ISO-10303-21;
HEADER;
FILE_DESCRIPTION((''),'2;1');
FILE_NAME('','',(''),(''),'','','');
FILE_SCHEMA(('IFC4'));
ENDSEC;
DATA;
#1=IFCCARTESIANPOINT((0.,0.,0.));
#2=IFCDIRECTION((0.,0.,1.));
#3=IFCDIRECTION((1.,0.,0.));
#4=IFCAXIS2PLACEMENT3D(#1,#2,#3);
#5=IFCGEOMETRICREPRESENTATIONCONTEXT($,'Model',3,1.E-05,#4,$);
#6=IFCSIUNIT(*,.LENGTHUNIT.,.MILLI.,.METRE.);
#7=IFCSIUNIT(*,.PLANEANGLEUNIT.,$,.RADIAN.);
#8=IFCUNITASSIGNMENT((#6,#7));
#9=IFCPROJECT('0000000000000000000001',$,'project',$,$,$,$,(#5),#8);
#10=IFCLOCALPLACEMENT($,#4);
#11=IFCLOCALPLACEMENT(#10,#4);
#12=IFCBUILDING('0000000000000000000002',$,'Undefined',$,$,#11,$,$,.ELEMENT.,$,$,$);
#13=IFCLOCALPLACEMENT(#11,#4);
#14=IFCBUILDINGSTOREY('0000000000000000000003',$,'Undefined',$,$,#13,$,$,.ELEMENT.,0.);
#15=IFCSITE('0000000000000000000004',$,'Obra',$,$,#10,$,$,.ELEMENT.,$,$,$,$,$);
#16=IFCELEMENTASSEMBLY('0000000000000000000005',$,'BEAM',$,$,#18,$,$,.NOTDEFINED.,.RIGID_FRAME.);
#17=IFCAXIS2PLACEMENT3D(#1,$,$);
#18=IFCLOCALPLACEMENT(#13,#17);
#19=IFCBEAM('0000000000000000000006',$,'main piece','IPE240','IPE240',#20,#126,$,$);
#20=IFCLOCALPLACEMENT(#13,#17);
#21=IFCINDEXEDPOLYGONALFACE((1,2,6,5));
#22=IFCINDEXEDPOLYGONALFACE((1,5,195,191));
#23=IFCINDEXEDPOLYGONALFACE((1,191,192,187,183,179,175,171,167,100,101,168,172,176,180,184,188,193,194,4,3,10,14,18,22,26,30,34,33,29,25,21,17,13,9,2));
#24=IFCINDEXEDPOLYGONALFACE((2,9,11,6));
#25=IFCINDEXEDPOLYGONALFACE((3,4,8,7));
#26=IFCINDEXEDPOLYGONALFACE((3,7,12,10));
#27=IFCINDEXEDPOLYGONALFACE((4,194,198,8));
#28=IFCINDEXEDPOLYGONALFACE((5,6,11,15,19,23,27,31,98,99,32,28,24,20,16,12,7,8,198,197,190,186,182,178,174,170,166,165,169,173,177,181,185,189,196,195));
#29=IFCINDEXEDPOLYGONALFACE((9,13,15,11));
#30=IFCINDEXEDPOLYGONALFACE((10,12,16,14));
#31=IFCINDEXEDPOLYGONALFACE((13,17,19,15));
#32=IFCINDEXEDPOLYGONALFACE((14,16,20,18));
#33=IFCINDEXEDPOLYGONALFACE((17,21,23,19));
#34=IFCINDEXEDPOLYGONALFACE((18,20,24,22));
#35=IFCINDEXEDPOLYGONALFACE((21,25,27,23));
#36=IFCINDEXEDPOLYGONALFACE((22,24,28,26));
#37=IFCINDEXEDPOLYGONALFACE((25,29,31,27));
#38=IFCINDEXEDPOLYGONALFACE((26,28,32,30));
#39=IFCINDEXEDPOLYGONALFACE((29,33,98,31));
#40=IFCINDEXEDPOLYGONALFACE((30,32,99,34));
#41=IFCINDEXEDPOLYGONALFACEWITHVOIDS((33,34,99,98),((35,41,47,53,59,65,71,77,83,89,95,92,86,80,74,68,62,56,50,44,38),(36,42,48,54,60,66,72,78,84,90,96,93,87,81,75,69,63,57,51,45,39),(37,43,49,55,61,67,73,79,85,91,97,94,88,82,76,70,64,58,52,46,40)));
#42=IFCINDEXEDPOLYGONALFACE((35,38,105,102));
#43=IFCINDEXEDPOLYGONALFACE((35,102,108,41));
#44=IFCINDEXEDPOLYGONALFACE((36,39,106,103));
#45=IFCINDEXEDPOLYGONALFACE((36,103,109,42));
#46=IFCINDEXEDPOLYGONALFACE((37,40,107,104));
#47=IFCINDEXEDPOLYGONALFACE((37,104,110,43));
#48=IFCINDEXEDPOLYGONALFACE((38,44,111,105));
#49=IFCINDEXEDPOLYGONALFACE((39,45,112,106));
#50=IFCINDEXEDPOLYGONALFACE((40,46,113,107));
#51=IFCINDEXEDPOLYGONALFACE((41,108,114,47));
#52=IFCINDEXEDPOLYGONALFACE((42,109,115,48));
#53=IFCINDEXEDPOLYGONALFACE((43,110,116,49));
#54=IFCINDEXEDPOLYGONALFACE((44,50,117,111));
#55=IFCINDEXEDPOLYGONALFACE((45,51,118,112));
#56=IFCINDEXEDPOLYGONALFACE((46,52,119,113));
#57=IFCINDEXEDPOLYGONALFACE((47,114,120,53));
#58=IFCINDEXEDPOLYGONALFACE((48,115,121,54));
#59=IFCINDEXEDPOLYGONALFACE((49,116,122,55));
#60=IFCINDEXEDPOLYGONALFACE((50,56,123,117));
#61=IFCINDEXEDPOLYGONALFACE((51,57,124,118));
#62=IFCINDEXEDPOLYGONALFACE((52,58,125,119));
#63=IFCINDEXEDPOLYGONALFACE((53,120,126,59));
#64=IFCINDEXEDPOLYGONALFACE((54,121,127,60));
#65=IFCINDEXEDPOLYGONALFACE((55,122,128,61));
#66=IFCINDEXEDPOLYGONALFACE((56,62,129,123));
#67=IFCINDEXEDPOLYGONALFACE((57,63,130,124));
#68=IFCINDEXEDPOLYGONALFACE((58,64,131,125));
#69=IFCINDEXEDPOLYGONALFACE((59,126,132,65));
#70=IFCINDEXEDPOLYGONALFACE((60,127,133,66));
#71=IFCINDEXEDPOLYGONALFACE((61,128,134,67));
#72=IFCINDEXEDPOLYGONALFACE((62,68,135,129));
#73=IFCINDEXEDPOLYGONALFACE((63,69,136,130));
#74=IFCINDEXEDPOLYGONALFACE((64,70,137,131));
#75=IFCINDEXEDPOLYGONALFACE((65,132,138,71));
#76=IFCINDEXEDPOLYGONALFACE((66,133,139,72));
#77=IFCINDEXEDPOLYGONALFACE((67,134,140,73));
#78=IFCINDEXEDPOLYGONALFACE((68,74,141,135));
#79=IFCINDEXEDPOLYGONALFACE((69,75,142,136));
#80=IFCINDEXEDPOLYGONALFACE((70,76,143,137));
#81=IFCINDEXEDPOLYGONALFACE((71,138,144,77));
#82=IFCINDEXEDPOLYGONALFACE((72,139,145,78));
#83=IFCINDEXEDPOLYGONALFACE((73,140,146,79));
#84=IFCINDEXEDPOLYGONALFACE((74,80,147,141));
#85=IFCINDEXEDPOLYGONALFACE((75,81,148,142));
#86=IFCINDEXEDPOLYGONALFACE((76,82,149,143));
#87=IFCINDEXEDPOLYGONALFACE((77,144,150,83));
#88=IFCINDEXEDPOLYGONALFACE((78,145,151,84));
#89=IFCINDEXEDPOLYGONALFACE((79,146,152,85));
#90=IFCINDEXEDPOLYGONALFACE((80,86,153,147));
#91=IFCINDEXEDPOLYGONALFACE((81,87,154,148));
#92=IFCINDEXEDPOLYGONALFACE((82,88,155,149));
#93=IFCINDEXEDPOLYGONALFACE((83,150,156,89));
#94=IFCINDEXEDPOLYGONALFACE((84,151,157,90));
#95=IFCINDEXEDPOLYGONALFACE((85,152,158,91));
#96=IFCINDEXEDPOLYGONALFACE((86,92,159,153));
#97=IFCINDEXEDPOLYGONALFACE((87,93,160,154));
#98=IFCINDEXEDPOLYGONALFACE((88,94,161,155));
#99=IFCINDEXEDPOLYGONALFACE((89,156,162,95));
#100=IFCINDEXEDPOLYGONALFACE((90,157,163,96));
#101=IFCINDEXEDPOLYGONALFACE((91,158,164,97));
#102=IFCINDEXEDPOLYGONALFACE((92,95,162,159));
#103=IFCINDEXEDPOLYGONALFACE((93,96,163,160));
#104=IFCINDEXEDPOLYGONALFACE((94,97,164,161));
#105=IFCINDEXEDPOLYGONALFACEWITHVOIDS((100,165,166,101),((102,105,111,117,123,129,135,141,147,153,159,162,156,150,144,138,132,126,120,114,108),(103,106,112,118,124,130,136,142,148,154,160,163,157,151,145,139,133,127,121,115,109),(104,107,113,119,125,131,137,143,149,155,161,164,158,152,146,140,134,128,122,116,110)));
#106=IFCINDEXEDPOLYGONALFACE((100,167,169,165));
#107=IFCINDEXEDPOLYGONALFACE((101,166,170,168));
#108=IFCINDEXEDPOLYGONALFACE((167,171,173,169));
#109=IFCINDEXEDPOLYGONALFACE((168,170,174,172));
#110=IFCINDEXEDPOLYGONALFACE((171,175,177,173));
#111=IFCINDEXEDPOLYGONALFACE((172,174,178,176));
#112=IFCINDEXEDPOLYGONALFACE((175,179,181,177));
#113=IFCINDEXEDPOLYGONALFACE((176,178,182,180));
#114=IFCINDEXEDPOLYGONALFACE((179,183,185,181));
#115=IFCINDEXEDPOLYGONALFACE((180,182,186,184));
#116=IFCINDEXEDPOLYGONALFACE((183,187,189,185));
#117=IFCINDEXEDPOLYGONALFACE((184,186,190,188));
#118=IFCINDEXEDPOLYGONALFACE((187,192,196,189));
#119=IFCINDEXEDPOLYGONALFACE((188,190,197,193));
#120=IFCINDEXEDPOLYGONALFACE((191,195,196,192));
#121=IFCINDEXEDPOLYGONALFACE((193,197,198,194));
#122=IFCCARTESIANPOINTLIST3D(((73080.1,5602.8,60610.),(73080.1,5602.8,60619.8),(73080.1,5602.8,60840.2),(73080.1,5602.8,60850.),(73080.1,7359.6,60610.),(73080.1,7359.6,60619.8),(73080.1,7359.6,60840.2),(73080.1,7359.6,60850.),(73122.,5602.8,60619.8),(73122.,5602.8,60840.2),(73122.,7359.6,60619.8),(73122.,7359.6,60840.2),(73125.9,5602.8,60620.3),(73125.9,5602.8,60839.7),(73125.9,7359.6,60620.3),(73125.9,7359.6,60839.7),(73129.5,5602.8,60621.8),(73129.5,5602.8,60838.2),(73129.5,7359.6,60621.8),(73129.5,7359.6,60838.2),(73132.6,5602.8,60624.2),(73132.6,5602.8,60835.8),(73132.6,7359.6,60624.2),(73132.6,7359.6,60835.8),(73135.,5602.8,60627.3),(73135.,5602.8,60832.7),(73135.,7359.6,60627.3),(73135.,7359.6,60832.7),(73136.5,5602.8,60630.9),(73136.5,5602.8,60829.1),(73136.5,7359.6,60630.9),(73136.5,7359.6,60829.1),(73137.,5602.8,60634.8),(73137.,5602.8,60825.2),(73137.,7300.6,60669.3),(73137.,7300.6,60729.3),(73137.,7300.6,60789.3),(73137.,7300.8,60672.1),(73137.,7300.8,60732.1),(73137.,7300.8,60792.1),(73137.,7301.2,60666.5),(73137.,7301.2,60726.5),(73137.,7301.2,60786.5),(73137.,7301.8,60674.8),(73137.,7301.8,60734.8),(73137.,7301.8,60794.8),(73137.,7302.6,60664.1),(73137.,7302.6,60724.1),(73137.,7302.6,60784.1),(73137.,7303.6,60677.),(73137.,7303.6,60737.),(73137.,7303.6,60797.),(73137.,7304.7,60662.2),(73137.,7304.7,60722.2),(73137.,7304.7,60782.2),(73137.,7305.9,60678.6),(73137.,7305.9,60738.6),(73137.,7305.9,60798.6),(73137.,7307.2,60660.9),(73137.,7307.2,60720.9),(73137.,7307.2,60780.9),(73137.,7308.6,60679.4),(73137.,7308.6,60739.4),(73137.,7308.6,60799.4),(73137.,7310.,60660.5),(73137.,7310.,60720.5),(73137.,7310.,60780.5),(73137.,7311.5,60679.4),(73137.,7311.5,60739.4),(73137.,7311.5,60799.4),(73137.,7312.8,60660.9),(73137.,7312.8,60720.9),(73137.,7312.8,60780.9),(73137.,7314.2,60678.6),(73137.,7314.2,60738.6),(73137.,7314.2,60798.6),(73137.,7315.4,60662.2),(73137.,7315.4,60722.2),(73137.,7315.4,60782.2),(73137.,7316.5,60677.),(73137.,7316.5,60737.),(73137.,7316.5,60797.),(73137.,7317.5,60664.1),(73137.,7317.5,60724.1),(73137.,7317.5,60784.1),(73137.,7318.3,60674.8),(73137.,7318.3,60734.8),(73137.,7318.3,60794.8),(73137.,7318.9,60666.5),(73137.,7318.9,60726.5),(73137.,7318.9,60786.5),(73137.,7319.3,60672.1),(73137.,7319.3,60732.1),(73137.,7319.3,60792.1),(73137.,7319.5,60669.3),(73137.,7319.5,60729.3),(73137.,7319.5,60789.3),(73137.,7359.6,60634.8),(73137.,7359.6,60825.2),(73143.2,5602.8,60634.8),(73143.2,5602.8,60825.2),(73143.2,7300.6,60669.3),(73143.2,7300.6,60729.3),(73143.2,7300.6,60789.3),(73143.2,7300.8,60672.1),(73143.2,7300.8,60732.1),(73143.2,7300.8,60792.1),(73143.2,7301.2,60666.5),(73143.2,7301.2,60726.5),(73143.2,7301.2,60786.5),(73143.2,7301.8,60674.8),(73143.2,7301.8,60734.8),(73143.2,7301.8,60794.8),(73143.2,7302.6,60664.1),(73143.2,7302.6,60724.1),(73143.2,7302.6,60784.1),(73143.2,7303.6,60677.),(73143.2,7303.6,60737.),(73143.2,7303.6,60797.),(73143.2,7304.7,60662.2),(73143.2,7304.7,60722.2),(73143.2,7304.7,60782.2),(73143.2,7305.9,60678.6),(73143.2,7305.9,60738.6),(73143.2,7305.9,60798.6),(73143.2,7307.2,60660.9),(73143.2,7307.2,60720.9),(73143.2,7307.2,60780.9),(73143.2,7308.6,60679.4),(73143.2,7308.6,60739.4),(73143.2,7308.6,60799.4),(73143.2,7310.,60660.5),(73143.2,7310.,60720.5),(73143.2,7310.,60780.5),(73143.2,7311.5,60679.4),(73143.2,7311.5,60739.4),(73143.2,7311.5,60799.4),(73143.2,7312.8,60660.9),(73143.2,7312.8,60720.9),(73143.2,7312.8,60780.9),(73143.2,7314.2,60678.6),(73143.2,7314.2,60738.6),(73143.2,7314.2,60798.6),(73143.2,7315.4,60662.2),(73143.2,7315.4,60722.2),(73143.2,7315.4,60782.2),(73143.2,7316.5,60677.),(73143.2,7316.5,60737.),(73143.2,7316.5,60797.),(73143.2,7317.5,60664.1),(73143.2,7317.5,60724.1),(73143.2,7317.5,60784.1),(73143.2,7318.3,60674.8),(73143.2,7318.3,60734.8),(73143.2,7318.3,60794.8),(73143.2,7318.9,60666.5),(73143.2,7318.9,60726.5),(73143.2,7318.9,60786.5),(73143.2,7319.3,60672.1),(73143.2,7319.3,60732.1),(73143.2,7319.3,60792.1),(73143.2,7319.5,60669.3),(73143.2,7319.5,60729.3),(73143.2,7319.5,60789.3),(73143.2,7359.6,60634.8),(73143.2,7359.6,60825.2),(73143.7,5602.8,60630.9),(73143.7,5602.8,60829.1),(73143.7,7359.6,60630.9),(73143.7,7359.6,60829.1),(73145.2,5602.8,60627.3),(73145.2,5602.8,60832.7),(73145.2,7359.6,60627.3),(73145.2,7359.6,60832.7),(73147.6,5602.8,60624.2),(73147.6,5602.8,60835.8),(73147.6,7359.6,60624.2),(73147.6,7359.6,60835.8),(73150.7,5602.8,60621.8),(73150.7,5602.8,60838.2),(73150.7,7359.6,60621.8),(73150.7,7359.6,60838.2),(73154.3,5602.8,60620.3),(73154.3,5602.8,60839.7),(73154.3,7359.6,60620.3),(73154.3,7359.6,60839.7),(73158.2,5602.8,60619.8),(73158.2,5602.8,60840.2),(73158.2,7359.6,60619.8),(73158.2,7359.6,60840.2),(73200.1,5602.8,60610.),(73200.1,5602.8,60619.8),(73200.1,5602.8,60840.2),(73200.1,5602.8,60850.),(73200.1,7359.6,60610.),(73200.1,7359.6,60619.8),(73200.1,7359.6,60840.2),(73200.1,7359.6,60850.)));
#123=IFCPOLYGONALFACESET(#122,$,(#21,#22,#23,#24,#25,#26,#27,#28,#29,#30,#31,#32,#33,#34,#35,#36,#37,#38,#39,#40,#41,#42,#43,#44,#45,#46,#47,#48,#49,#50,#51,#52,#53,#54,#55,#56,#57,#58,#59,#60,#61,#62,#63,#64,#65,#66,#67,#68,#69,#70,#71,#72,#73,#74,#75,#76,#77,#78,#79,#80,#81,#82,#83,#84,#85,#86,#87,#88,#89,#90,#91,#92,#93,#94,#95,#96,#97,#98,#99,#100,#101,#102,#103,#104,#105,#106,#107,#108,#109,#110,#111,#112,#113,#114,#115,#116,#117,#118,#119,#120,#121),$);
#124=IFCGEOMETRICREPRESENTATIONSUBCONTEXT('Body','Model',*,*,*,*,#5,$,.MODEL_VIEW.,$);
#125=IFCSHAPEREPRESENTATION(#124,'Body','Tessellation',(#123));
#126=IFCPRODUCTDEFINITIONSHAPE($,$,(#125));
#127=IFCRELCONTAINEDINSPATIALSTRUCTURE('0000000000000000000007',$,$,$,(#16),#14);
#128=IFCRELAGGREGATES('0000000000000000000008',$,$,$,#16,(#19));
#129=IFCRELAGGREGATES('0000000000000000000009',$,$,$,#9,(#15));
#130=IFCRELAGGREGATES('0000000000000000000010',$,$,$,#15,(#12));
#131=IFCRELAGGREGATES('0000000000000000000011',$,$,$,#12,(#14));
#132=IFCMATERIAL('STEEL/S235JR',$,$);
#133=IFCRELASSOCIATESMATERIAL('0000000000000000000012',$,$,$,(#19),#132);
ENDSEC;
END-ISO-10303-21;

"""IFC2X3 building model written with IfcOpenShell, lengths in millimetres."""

from ifc_helpers import new_model, si_unit, frame, origin_with_axes, origin_2d_with_axis, place, context, subcontext, project, spatial, circle, i_section, extrude, clip, halfspace, source, transform, mapped, material, element, aggregate, save


model = new_model("IFC2X3")

# Units and contexts
model_context = context("Model", 3, precision=1e-05, world=origin_with_axes())
body_context = subcontext(model_context, "Body", "Model", "MODEL_VIEW")
ifc_project = project(units=[si_unit("LENGTHUNIT", "METRE", prefix="MILLI"), si_unit("PLANEANGLEUNIT", "RADIAN")], contexts=[model_context])

# Site, building, storey
site_placement = place(None, origin_with_axes())
site = spatial("IfcSite", under=ifc_project, at=site_placement, Name="Obra", CompositionType="ELEMENT")
building_placement = place(site_placement, origin_with_axes())
building = spatial("IfcBuilding", under=site, at=building_placement, Name="Undefined", CompositionType="ELEMENT")
storey_placement = place(building_placement, origin_with_axes())
storey = spatial("IfcBuildingStorey", under=building, at=storey_placement, Name="Undefined", CompositionType="ELEMENT", Elevation=0.0)

# Shared definitions
ifc_material_1 = material(Name="STEEL/S235JR")

# Element assembly, beam, opening
assembly_1_placement = place(storey_placement, origin_with_axes())
assembly_1 = element("IfcElementAssembly", 1, at=assembly_1_placement, inside=storey, Name="BEAM", AssemblyPlace="NOTDEFINED", PredefinedType="RIGID_FRAME")
beam_1_placement = place(assembly_1_placement, frame((73140.1, 5602.8, 60730.0), z_axis=(0.0, 0.0, 1.0), x_axis=(0.0, 1.0, 0.0)))
beam_1 = element("IfcBeam", 2, at=beam_1_placement, material=ifc_material_1, Name="main piece", Description="IPE240", ObjectType="IPE240", context=body_context, shape_type="Clipping", body=[
    clip(extrude(i_section(OverallWidth=120.0, OverallDepth=240.0, WebThickness=6.2, FlangeThickness=9.8, FilletRadius=15.0, at=origin_2d_with_axis()), frame((1756.8, 0.0, 0.0), z_axis=(-1.0, 0.0, 0.0), x_axis=(0.0, -1.0, 0.0)), (0.0, 0.0, 1.0), 1756.8), halfspace(frame((1756.8, -60.0, -120.0), z_axis=(1.0, 0.0, 0.0), x_axis=(0.0, 0.0, 1.0)), False)),
])
shared_shape_1 = source(origin_with_axes(), body_context, "Body", "SweptSolid", [
    extrude(circle(Radius=9.5, at=origin_2d_with_axis()), frame((0.0, -3.2, 0.0), z_axis=(0.0, 1.0, 0.0), x_axis=(1.0, 0.0, 0.0)), (0.0, 0.0, 1.0), 6.4),
])
opening_1_placement = place(assembly_1_placement, frame((73140.1, 7360.0, 60850.0), z_axis=(-0.000019, -1.0, 0.0), x_axis=(0.0, 0.0, -1.0)))
element("IfcOpeningElement", 3, at=opening_1_placement, cuts=beam_1, ObjectType="Opening", context=body_context, shape_type="MappedRepresentation", body=[
    mapped(shared_shape_1, transform((60.0, 0.0, 50.0))),
    mapped(shared_shape_1, transform((120.0, 0.0, 50.0))),
    mapped(shared_shape_1, transform((180.0, 0.0, 50.0))),
])
aggregate(assembly_1, [beam_1])

save(model, "model.ifc")
